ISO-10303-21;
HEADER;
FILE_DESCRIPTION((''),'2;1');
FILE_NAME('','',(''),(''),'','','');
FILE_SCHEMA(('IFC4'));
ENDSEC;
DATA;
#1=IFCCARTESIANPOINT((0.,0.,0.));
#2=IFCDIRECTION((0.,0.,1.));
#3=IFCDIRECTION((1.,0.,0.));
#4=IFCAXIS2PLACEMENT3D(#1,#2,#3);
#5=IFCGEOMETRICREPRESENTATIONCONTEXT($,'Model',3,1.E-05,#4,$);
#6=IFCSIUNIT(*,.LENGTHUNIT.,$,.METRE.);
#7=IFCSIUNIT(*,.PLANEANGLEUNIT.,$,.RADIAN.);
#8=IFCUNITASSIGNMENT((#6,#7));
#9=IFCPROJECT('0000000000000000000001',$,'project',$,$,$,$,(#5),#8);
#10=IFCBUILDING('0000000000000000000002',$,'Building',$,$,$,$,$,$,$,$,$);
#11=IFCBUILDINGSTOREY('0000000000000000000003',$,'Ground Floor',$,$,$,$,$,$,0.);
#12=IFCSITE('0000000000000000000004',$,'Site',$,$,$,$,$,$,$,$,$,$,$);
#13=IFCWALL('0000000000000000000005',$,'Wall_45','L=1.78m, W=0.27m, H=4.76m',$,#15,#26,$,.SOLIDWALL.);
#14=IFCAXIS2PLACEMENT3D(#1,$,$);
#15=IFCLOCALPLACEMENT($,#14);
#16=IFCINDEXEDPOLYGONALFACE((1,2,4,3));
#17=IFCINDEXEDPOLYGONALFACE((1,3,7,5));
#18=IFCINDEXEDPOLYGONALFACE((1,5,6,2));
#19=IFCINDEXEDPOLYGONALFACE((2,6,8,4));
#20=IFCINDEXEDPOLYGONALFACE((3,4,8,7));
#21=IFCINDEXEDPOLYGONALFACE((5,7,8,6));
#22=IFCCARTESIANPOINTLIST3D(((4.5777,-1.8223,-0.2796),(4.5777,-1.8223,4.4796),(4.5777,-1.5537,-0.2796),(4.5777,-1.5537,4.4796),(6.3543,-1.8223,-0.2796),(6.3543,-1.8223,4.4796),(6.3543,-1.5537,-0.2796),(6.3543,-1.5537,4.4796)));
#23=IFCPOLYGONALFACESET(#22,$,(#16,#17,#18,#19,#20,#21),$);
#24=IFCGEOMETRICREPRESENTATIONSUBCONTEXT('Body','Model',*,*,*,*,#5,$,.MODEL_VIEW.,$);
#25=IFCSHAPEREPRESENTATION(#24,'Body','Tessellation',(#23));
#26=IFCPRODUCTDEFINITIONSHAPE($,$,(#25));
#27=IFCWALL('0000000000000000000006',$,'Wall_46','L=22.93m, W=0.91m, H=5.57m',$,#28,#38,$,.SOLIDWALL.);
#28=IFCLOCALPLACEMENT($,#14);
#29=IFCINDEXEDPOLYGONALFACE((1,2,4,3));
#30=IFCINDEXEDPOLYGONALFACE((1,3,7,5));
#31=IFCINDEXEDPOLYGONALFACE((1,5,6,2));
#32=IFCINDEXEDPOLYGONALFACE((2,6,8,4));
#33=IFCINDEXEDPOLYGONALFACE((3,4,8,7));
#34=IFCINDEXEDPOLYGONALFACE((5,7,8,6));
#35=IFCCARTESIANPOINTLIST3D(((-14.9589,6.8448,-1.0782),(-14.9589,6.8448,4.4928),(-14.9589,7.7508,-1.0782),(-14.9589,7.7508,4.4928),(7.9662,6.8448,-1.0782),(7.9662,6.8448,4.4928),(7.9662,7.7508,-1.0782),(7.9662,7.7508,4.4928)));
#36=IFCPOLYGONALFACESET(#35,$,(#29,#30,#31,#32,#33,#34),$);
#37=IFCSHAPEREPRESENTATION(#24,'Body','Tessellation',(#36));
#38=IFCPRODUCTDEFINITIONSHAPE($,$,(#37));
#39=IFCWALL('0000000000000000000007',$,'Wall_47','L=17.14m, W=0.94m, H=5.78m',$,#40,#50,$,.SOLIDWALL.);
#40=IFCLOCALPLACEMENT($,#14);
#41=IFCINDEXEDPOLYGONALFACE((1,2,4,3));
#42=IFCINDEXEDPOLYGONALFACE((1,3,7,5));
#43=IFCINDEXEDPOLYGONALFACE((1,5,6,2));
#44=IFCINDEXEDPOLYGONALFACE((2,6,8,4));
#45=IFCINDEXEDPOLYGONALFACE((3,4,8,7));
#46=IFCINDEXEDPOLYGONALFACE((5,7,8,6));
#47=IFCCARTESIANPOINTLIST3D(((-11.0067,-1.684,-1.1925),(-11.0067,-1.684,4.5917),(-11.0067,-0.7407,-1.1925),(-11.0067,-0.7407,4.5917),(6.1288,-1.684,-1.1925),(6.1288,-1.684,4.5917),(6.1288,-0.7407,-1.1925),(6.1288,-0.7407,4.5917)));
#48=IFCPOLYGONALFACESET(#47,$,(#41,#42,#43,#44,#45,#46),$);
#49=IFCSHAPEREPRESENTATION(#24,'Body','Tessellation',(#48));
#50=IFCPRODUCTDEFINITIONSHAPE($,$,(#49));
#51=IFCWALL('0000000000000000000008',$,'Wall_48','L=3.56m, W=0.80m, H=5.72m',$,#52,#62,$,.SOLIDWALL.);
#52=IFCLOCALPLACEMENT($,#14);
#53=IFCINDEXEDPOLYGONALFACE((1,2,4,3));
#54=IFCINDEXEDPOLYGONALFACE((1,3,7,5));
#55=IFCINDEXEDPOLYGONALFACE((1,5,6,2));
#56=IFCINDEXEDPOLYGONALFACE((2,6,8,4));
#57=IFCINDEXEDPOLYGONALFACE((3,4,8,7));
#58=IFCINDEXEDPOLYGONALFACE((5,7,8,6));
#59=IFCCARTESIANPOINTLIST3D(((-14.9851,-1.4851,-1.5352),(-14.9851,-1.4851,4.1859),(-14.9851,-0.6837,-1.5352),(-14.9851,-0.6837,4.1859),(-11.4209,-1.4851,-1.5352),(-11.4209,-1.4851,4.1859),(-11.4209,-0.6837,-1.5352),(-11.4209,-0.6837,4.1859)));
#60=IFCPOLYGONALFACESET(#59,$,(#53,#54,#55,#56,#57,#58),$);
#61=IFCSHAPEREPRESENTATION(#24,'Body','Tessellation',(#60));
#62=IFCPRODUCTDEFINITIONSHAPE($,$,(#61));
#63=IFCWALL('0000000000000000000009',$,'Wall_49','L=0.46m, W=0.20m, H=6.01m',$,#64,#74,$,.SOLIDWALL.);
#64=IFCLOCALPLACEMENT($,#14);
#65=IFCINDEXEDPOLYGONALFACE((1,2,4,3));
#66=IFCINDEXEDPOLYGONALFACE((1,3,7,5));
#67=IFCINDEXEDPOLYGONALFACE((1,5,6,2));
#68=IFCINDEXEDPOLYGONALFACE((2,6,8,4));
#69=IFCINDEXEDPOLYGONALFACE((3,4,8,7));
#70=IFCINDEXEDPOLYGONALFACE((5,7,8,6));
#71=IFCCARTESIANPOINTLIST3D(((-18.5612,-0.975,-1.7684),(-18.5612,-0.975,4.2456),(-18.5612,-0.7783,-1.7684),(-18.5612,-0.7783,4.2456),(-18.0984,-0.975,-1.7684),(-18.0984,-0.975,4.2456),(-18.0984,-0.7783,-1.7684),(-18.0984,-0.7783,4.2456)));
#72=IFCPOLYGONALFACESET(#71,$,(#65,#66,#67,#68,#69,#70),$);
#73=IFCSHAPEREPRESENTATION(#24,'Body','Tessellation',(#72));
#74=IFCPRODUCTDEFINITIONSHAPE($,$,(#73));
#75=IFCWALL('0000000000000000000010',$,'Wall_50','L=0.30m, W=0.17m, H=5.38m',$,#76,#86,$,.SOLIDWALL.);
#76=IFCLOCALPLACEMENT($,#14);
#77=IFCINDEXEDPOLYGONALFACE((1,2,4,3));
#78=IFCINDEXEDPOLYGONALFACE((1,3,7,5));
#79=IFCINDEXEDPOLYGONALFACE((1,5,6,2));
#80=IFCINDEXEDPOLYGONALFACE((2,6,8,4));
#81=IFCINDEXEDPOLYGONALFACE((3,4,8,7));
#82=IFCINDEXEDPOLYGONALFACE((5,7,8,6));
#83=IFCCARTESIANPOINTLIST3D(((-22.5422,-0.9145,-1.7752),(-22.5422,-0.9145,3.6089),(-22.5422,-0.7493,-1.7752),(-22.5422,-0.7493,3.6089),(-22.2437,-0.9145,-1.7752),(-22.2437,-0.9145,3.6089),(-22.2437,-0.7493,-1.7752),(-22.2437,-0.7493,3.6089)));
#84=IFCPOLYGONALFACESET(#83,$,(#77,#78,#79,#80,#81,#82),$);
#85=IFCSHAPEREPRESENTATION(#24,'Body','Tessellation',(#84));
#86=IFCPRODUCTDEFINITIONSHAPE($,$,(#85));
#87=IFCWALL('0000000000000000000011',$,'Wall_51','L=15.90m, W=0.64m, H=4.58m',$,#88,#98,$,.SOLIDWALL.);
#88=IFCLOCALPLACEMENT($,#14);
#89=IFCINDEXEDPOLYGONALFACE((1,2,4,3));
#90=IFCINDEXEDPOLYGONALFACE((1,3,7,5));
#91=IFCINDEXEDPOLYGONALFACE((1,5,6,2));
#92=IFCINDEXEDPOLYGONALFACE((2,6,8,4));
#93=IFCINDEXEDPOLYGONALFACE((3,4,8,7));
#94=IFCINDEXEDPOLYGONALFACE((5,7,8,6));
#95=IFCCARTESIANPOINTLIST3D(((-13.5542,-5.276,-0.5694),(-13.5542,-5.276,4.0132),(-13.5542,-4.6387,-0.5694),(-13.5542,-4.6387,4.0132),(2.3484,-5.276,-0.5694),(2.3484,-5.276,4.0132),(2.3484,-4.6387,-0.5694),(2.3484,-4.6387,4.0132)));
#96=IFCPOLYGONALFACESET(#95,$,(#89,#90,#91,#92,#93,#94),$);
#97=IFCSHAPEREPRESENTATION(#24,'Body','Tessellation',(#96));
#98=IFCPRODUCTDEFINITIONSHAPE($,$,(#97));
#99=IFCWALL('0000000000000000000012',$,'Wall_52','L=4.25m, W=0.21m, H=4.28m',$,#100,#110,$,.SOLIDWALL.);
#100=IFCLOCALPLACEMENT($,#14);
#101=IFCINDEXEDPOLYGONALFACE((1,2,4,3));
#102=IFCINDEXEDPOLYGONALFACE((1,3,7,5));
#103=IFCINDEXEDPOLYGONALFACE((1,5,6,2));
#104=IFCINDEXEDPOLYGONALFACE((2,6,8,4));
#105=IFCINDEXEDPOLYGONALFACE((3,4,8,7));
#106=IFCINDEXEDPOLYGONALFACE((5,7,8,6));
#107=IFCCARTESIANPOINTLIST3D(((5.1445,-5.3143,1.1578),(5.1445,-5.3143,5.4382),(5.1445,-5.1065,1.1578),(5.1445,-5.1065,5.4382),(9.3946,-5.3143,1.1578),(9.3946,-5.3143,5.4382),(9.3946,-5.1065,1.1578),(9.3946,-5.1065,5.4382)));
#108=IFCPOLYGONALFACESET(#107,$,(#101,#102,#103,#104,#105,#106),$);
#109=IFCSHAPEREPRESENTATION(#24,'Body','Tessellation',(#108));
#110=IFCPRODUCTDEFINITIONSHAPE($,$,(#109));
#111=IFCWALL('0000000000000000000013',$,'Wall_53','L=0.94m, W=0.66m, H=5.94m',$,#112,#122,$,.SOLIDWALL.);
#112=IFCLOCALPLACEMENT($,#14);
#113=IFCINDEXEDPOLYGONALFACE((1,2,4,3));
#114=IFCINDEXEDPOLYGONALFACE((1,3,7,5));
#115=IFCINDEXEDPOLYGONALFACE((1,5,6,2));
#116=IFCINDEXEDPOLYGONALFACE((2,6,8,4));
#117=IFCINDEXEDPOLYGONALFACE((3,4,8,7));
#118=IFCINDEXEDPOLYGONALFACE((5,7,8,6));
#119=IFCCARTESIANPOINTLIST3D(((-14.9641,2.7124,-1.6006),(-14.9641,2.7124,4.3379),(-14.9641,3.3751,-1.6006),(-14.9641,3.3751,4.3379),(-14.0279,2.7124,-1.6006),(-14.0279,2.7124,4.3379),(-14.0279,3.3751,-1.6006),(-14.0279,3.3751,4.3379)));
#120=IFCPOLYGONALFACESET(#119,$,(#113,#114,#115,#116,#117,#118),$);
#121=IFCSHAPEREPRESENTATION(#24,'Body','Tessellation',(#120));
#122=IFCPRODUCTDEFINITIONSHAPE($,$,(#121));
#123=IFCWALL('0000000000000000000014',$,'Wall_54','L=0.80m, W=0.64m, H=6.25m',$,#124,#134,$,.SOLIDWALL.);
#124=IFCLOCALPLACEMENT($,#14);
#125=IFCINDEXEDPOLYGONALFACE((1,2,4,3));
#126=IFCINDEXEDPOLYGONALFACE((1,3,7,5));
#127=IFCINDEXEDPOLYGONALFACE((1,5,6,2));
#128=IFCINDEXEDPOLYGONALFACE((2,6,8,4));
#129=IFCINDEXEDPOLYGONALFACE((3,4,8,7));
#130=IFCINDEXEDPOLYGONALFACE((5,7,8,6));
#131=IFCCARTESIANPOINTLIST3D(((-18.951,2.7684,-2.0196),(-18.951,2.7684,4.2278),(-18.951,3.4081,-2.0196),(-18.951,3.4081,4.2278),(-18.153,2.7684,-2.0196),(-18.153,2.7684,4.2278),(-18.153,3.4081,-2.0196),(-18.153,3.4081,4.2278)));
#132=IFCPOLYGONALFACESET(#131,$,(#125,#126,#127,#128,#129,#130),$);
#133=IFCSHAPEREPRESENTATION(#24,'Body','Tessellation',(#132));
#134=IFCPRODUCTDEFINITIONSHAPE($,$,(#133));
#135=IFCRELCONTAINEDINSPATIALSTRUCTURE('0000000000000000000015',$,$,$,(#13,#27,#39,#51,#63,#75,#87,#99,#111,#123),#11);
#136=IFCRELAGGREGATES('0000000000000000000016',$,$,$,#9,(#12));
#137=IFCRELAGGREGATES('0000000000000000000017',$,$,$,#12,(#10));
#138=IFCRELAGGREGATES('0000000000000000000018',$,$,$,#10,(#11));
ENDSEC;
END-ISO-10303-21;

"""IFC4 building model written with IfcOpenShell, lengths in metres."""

from ifc_helpers import new_model, si_unit, frame, origin_with_axes, origin_2d, context, subcontext, project, spatial, rectangle, extrude, element, save


model = new_model("IFC4")

# Units and contexts
model_context = context("Model", 3, precision=1e-05, world=origin_with_axes())
body_context = subcontext(model_context, "Body", "Model", "MODEL_VIEW")
ifc_project = project(units=[si_unit("LENGTHUNIT", "METRE"), si_unit("PLANEANGLEUNIT", "RADIAN")], contexts=[model_context])

# Site, building, storey
site = spatial("IfcSite", under=ifc_project, Name="Site")
building = spatial("IfcBuilding", under=site, Name="Building")
storey = spatial("IfcBuildingStorey", under=building, Name="Ground Floor", Elevation=0.0)

# Walls
element("IfcWall", 1, inside=storey, Name="Wall_45", Description="L=1.78m, W=0.27m, H=4.76m", PredefinedType="SOLIDWALL", context=body_context, shape_type="SweptSolid", body=[
    extrude(rectangle(XDim=1.7765, YDim=0.2686, at=origin_2d()), frame((5.466, -1.688, -0.2796), z_axis=(0.0, 0.0, 1.0), x_axis=(1.0, 0.0, 0.0)), (0.0, 0.0, 1.0), 4.7592),
])
element("IfcWall", 2, inside=storey, Name="Wall_46", Description="L=22.93m, W=0.91m, H=5.57m", PredefinedType="SOLIDWALL", context=body_context, shape_type="SweptSolid", body=[
    extrude(rectangle(XDim=22.9251, YDim=0.906, at=origin_2d()), frame((-3.4964, 7.2978, -1.0782), z_axis=(0.0, 0.0, 1.0), x_axis=(1.0, 0.0, 0.0)), (0.0, 0.0, 1.0), 5.571),
])
element("IfcWall", 3, inside=storey, Name="Wall_47", Description="L=17.14m, W=0.94m, H=5.78m", PredefinedType="SOLIDWALL", context=body_context, shape_type="SweptSolid", body=[
    extrude(rectangle(XDim=17.1355, YDim=0.9433, at=origin_2d()), frame((-2.4389, -1.2124, -1.1925), z_axis=(0.0, 0.0, 1.0), x_axis=(1.0, 0.0, 0.0)), (0.0, 0.0, 1.0), 5.7842),
])
element("IfcWall", 4, inside=storey, Name="Wall_48", Description="L=3.56m, W=0.80m, H=5.72m", PredefinedType="SOLIDWALL", context=body_context, shape_type="SweptSolid", body=[
    extrude(rectangle(XDim=3.5642, YDim=0.8014, at=origin_2d()), frame((-13.203, -1.0844, -1.5352), z_axis=(0.0, 0.0, 1.0), x_axis=(1.0, 0.0, 0.0)), (0.0, 0.0, 1.0), 5.7211),
])
element("IfcWall", 5, inside=storey, Name="Wall_49", Description="L=0.46m, W=0.20m, H=6.01m", PredefinedType="SOLIDWALL", context=body_context, shape_type="SweptSolid", body=[
    extrude(rectangle(XDim=0.4628, YDim=0.1967, at=origin_2d()), frame((-18.3298, -0.8766, -1.7684), z_axis=(0.0, 0.0, 1.0), x_axis=(1.0, 0.0, 0.0)), (0.0, 0.0, 1.0), 6.014),
])
element("IfcWall", 6, inside=storey, Name="Wall_50", Description="L=0.30m, W=0.17m, H=5.38m", PredefinedType="SOLIDWALL", context=body_context, shape_type="SweptSolid", body=[
    extrude(rectangle(XDim=0.2985, YDim=0.1652, at=origin_2d()), frame((-22.3929, -0.8319, -1.7752), z_axis=(0.0, 0.0, 1.0), x_axis=(1.0, 0.0, 0.0)), (0.0, 0.0, 1.0), 5.3841),
])
element("IfcWall", 7, inside=storey, Name="Wall_51", Description="L=15.90m, W=0.64m, H=4.58m", PredefinedType="SOLIDWALL", context=body_context, shape_type="SweptSolid", body=[
    extrude(rectangle(XDim=15.9026, YDim=0.6373, at=origin_2d()), frame((-5.6029, -4.9573, -0.5694), z_axis=(0.0, 0.0, 1.0), x_axis=(1.0, 0.0, 0.0)), (0.0, 0.0, 1.0), 4.5827),
])
element("IfcWall", 8, inside=storey, Name="Wall_52", Description="L=4.25m, W=0.21m, H=4.28m", PredefinedType="SOLIDWALL", context=body_context, shape_type="SweptSolid", body=[
    extrude(rectangle(XDim=4.2501, YDim=0.2079, at=origin_2d()), frame((7.2695, -5.2104, 1.1578), z_axis=(0.0, 0.0, 1.0), x_axis=(1.0, 0.0, 0.0)), (0.0, 0.0, 1.0), 4.2804),
])
element("IfcWall", 9, inside=storey, Name="Wall_53", Description="L=0.94m, W=0.66m, H=5.94m", PredefinedType="SOLIDWALL", context=body_context, shape_type="SweptSolid", body=[
    extrude(rectangle(XDim=0.9362, YDim=0.6626, at=origin_2d()), frame((-14.496, 3.0438, -1.6006), z_axis=(0.0, 0.0, 1.0), x_axis=(1.0, 0.0, 0.0)), (0.0, 0.0, 1.0), 5.9385),
])
element("IfcWall", 10, inside=storey, Name="Wall_54", Description="L=0.80m, W=0.64m, H=6.25m", PredefinedType="SOLIDWALL", context=body_context, shape_type="SweptSolid", body=[
    extrude(rectangle(XDim=0.7979, YDim=0.6396, at=origin_2d()), frame((-18.552, 3.0883, -2.0196), z_axis=(0.0, 0.0, 1.0), x_axis=(1.0, 0.0, 0.0)), (0.0, 0.0, 1.0), 6.2474),
])

save(model, "model.ifc")
